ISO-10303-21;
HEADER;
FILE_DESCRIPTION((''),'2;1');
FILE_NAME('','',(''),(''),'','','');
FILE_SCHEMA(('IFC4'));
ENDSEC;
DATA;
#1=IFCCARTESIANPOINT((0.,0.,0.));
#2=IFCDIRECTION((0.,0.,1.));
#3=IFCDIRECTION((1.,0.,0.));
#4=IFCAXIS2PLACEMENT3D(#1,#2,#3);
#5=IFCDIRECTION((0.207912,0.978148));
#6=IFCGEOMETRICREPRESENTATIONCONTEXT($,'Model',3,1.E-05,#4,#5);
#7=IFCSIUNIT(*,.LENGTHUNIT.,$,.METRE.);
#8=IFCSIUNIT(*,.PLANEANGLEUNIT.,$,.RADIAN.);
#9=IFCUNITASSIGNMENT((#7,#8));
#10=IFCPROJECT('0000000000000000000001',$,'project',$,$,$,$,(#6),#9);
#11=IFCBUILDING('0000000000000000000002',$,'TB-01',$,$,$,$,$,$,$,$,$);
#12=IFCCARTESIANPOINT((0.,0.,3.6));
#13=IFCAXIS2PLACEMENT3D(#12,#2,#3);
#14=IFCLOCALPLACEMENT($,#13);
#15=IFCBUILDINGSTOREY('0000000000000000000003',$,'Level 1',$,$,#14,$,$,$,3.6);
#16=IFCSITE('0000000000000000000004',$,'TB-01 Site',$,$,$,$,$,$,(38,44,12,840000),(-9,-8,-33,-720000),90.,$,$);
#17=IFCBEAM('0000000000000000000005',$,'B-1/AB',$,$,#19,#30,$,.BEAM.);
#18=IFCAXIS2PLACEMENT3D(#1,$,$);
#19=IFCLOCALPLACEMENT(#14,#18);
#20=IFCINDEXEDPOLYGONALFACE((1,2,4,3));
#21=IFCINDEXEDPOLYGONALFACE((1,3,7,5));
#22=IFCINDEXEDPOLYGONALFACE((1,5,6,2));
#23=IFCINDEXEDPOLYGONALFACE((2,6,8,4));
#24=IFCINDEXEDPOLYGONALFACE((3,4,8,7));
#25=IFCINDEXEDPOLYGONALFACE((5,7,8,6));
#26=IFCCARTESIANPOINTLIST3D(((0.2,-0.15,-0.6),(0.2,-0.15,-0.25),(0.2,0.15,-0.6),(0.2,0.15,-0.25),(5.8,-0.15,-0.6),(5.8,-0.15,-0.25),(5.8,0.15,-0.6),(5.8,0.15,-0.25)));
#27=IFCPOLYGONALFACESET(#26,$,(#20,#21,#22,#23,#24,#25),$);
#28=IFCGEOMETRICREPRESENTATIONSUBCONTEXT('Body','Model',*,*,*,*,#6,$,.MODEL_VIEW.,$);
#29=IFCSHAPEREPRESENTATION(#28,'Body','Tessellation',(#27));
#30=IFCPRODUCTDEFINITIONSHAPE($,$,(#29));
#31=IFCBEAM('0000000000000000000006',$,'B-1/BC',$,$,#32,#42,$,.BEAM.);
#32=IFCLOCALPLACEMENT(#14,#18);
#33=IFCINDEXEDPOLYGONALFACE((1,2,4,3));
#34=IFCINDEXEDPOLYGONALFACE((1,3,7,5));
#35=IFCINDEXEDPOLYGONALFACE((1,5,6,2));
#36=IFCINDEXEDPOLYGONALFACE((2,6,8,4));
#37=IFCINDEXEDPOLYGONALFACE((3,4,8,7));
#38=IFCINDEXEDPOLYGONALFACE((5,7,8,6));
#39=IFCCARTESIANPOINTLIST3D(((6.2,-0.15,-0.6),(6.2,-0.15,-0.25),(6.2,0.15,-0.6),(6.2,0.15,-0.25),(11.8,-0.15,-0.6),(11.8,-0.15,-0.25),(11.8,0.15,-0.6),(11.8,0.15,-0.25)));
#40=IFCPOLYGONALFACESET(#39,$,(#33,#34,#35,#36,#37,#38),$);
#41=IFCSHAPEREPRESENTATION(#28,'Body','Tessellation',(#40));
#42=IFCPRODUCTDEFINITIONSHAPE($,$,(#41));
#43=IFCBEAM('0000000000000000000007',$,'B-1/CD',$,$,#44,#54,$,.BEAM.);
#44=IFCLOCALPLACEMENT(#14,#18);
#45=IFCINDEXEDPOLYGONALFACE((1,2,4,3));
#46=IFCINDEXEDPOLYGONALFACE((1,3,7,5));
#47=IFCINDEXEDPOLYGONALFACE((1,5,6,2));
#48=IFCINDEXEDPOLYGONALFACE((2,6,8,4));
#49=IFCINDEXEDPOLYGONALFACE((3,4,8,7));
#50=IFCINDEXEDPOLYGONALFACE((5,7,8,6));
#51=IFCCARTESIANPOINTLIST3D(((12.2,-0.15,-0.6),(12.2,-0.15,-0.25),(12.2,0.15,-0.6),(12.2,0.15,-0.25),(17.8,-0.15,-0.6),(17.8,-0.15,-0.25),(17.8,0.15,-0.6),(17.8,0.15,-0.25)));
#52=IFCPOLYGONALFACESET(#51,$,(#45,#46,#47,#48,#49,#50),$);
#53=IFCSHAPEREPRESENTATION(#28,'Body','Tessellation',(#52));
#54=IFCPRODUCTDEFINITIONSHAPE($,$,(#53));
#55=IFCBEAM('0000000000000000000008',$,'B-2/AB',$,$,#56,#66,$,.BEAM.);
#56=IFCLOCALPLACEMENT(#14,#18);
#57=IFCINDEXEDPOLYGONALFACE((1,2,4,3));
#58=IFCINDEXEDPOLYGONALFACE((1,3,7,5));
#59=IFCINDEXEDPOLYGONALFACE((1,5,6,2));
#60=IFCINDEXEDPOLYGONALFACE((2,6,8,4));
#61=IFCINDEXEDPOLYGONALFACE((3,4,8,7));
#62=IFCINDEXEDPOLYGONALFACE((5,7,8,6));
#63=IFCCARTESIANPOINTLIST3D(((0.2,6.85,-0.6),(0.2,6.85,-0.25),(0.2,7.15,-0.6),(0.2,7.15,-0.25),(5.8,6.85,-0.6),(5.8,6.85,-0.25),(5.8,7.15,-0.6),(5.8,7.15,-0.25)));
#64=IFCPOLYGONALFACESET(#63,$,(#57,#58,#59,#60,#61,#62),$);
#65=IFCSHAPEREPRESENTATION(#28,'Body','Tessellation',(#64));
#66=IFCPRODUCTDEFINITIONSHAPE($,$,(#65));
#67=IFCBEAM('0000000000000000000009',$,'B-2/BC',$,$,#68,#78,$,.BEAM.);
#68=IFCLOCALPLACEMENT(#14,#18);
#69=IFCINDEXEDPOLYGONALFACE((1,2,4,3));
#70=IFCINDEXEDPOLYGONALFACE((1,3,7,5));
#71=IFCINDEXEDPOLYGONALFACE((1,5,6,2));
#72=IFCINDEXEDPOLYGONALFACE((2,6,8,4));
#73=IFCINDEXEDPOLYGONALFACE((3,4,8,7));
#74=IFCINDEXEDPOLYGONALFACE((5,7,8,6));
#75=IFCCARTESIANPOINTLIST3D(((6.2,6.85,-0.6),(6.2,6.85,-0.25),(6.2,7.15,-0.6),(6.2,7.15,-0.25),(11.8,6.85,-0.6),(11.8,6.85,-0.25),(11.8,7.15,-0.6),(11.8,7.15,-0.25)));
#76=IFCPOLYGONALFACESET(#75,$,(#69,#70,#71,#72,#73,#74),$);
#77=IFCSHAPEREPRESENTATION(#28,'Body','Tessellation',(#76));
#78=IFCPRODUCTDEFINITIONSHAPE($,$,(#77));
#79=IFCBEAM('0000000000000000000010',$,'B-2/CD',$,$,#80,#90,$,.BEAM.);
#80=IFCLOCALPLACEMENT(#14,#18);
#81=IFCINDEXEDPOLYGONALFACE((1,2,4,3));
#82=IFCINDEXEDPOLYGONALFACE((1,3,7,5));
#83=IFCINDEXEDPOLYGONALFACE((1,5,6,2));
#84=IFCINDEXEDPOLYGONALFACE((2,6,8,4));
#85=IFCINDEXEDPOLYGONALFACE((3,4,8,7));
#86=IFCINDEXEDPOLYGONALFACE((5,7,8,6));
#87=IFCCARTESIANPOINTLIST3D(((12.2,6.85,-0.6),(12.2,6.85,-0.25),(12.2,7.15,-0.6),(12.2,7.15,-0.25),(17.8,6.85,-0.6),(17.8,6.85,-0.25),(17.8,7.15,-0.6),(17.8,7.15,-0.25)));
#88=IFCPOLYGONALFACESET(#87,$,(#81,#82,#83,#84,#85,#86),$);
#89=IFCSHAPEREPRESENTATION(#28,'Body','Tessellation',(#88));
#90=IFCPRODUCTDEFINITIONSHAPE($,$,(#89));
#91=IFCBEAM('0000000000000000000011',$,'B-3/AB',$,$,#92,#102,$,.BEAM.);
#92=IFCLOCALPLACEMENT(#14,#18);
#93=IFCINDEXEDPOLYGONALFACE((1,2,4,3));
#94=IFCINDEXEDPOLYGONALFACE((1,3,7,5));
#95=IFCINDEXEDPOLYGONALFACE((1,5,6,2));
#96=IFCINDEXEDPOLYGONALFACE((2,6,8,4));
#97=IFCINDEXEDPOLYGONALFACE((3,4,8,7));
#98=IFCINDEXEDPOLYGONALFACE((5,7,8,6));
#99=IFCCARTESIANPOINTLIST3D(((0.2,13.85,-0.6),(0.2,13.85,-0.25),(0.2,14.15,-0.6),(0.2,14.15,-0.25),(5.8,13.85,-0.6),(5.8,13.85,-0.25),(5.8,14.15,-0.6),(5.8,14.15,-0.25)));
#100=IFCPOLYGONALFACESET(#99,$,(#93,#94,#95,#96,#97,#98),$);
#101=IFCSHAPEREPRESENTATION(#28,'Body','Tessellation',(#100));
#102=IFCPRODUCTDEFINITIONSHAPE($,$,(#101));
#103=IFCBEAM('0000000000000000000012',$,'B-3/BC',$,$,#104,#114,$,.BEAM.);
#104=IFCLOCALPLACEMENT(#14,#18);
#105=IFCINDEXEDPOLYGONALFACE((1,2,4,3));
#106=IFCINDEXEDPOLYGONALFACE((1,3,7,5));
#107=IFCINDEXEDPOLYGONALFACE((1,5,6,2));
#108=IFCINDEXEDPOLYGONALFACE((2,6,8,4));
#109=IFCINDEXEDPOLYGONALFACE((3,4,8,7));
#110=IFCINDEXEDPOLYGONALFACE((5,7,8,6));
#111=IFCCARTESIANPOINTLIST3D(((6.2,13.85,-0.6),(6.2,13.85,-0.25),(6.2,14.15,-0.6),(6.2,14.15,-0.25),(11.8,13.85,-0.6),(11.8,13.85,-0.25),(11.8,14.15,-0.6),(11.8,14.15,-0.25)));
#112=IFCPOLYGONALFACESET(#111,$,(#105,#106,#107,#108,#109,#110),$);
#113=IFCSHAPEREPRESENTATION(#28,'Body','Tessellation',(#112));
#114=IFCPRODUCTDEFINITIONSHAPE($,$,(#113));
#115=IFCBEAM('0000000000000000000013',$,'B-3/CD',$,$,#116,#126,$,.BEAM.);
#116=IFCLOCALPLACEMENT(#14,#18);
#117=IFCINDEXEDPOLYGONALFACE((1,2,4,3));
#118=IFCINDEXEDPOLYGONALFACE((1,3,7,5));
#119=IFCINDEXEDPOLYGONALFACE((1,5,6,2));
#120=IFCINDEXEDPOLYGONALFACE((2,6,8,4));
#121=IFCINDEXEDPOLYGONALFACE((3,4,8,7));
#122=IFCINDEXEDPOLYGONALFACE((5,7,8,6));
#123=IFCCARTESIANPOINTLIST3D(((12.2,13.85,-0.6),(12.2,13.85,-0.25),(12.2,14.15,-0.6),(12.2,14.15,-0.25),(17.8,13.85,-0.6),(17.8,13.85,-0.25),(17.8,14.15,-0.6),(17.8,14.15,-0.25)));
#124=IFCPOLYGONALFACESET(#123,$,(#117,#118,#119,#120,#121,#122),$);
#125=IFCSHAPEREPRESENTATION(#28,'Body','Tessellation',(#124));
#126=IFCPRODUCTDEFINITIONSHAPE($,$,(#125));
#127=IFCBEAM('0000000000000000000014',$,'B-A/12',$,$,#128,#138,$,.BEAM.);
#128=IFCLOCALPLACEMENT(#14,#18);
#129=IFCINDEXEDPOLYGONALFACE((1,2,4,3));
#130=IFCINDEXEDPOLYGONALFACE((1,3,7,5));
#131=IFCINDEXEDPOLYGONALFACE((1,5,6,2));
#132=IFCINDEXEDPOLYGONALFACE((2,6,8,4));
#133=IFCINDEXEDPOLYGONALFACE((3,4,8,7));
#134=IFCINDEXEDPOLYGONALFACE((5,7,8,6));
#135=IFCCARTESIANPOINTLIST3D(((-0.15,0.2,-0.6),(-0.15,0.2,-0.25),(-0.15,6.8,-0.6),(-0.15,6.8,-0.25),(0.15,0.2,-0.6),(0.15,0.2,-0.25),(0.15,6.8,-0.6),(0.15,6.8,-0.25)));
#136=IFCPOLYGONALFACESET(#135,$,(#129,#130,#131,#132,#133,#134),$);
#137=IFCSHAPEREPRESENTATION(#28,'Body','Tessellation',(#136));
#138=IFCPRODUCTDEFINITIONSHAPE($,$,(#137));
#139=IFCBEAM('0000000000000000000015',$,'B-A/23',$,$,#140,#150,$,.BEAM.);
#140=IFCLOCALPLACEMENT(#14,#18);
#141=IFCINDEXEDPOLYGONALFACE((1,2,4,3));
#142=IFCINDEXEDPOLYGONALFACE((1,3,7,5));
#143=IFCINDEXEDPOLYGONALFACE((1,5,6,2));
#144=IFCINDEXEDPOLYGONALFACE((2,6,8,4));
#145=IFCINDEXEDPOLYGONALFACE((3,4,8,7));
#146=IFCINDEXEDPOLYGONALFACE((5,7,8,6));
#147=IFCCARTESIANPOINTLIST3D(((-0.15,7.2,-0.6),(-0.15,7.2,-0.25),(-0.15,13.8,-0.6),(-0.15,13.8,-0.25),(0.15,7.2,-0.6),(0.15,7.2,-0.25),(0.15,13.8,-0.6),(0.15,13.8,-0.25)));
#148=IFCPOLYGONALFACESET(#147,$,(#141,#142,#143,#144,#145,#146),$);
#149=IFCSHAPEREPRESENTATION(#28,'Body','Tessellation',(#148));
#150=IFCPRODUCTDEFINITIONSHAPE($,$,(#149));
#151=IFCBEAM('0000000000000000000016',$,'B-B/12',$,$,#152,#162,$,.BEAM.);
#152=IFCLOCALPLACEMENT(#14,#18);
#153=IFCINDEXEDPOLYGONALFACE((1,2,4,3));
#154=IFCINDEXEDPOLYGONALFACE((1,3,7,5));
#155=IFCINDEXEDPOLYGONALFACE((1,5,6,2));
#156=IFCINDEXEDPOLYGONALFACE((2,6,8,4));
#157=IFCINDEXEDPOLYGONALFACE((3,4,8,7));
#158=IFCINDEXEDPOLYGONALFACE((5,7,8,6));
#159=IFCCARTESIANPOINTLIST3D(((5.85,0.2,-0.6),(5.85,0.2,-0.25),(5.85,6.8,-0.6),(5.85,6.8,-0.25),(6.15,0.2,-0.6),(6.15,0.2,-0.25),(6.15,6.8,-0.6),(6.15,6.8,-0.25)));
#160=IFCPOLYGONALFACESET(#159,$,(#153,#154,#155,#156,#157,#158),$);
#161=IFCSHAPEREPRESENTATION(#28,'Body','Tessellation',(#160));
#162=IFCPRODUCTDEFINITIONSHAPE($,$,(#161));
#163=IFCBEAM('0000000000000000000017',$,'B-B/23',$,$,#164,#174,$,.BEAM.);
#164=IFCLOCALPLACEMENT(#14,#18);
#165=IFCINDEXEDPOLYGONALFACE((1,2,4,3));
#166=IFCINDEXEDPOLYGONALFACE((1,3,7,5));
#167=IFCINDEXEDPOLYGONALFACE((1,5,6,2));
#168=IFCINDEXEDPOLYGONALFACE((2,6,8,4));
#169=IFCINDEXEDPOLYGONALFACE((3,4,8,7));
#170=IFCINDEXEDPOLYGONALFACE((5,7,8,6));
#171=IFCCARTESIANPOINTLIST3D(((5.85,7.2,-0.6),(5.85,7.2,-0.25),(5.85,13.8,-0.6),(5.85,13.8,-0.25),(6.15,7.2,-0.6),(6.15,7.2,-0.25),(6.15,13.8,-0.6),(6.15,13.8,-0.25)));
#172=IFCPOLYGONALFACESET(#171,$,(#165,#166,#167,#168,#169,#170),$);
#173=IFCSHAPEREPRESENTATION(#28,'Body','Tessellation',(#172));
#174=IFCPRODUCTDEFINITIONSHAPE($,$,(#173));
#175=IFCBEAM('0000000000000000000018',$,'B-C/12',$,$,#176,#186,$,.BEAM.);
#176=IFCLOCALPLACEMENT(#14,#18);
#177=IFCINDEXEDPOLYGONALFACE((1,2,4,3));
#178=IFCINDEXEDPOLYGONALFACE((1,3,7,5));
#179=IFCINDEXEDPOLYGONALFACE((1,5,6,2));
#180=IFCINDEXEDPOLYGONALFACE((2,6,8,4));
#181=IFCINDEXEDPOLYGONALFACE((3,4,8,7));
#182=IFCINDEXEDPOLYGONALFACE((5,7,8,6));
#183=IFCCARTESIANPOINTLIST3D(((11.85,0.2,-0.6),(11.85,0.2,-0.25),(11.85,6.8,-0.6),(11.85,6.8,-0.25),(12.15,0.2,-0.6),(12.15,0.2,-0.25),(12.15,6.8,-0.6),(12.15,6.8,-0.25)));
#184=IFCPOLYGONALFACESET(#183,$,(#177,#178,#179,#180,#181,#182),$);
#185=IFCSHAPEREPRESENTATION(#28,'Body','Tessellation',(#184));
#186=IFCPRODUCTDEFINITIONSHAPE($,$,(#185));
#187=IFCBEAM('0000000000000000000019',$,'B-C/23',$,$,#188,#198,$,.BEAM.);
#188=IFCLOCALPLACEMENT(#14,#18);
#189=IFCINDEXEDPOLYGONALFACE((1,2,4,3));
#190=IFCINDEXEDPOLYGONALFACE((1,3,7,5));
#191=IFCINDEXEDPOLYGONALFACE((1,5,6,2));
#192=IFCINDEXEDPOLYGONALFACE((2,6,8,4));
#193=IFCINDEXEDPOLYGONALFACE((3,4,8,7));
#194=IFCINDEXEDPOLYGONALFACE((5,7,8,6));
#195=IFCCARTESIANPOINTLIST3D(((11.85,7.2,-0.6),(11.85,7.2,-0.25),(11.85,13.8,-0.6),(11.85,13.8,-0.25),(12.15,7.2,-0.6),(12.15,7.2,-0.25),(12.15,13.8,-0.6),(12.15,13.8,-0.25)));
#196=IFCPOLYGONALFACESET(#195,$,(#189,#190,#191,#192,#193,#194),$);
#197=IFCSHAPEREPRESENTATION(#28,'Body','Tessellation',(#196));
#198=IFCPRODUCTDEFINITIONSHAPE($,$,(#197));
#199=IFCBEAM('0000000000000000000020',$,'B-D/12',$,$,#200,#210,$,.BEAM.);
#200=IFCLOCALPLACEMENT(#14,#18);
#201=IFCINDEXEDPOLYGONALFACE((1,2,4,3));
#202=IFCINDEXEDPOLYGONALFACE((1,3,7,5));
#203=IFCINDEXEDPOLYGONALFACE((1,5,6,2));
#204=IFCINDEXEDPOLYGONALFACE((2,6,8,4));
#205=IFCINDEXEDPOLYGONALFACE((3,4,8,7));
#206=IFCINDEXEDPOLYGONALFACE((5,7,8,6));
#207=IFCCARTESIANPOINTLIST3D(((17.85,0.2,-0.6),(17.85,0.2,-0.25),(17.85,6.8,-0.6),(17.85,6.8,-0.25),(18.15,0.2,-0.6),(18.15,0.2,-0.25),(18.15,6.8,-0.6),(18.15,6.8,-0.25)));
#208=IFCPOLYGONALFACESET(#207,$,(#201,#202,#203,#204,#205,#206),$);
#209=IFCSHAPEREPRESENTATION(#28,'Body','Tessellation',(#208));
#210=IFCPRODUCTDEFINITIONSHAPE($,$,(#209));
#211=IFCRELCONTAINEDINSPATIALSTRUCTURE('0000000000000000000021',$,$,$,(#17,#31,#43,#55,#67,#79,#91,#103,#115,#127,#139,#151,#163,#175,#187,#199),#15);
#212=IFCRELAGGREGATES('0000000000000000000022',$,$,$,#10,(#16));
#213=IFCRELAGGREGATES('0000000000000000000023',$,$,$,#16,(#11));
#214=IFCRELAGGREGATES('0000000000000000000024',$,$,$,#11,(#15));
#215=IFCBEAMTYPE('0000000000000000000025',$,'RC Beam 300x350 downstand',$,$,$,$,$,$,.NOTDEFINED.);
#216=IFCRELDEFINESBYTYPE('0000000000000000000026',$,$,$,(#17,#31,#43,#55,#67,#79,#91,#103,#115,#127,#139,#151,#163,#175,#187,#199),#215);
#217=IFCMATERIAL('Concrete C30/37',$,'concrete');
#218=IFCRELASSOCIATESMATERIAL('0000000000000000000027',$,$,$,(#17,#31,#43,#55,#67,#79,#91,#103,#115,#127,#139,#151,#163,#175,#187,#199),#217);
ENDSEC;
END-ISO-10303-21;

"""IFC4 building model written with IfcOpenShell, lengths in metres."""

from ifc_helpers import new_model, si_unit, direction, frame, origin_with_axes, place, context, subcontext, project, spatial, rectangle, extrude, material, type_object, element, save


model = new_model("IFC4")

# Units and contexts
model_context = context("Model", 3, precision=1e-05, world=origin_with_axes(), true_north=direction((0.207912, 0.978148)))
body_context = subcontext(model_context, "Body", "Model", "MODEL_VIEW")
ifc_project = project(units=[si_unit("LENGTHUNIT", "METRE"), si_unit("PLANEANGLEUNIT", "RADIAN")], contexts=[model_context])

# Site, building, storey
site = spatial("IfcSite", under=ifc_project, Name="TB-01 Site", RefLatitude=(38, 44, 12, 840000), RefLongitude=(-9, -8, -33, -720000), RefElevation=90.0)
building = spatial("IfcBuilding", under=site, Name="TB-01")
storey_placement = place(None, frame((0.0, 0.0, 3.6), z_axis=(0.0, 0.0, 1.0), x_axis=(1.0, 0.0, 0.0)))
storey = spatial("IfcBuildingStorey", under=building, at=storey_placement, Name="Level 1", Elevation=3.6)

# Beams
ifc_material = material(Name="Concrete C30/37", Category="concrete")
beam_type = type_object("IfcBeamType", Name="RC Beam 300x350 downstand", PredefinedType="NOTDEFINED")
beam_1_placement = place(storey_placement, frame((0.2, 0.0, -0.425), z_axis=(1.0, 0.0, 0.0), x_axis=(0.0, 1.0, 0.0)))
element("IfcBeam", 1, at=beam_1_placement, inside=storey, type_object=beam_type, material=ifc_material, Name="B-1/AB", PredefinedType="BEAM", context=body_context, shape_type="SweptSolid", body=[
    extrude(rectangle(XDim=0.3, YDim=0.35), origin_with_axes(), (0.0, 0.0, 1.0), 5.6),
])
beam_2_placement = place(storey_placement, frame((6.2, 0.0, -0.425), z_axis=(1.0, 0.0, 0.0), x_axis=(0.0, 1.0, 0.0)))
element("IfcBeam", 2, at=beam_2_placement, inside=storey, type_object=beam_type, material=ifc_material, Name="B-1/BC", PredefinedType="BEAM", context=body_context, shape_type="SweptSolid", body=[
    extrude(rectangle(XDim=0.3, YDim=0.35), origin_with_axes(), (0.0, 0.0, 1.0), 5.6),
])
beam_3_placement = place(storey_placement, frame((12.2, 0.0, -0.425), z_axis=(1.0, 0.0, 0.0), x_axis=(0.0, 1.0, 0.0)))
element("IfcBeam", 3, at=beam_3_placement, inside=storey, type_object=beam_type, material=ifc_material, Name="B-1/CD", PredefinedType="BEAM", context=body_context, shape_type="SweptSolid", body=[
    extrude(rectangle(XDim=0.3, YDim=0.35), origin_with_axes(), (0.0, 0.0, 1.0), 5.6),
])
beam_4_placement = place(storey_placement, frame((0.2, 7.0, -0.425), z_axis=(1.0, 0.0, 0.0), x_axis=(0.0, 1.0, 0.0)))
element("IfcBeam", 4, at=beam_4_placement, inside=storey, type_object=beam_type, material=ifc_material, Name="B-2/AB", PredefinedType="BEAM", context=body_context, shape_type="SweptSolid", body=[
    extrude(rectangle(XDim=0.3, YDim=0.35), origin_with_axes(), (0.0, 0.0, 1.0), 5.6),
])
beam_5_placement = place(storey_placement, frame((6.2, 7.0, -0.425), z_axis=(1.0, 0.0, 0.0), x_axis=(0.0, 1.0, 0.0)))
element("IfcBeam", 5, at=beam_5_placement, inside=storey, type_object=beam_type, material=ifc_material, Name="B-2/BC", PredefinedType="BEAM", context=body_context, shape_type="SweptSolid", body=[
    extrude(rectangle(XDim=0.3, YDim=0.35), origin_with_axes(), (0.0, 0.0, 1.0), 5.6),
])
beam_6_placement = place(storey_placement, frame((12.2, 7.0, -0.425), z_axis=(1.0, 0.0, 0.0), x_axis=(0.0, 1.0, 0.0)))
element("IfcBeam", 6, at=beam_6_placement, inside=storey, type_object=beam_type, material=ifc_material, Name="B-2/CD", PredefinedType="BEAM", context=body_context, shape_type="SweptSolid", body=[
    extrude(rectangle(XDim=0.3, YDim=0.35), origin_with_axes(), (0.0, 0.0, 1.0), 5.6),
])
beam_7_placement = place(storey_placement, frame((0.2, 14.0, -0.425), z_axis=(1.0, 0.0, 0.0), x_axis=(0.0, 1.0, 0.0)))
element("IfcBeam", 7, at=beam_7_placement, inside=storey, type_object=beam_type, material=ifc_material, Name="B-3/AB", PredefinedType="BEAM", context=body_context, shape_type="SweptSolid", body=[
    extrude(rectangle(XDim=0.3, YDim=0.35), origin_with_axes(), (0.0, 0.0, 1.0), 5.6),
])
beam_8_placement = place(storey_placement, frame((6.2, 14.0, -0.425), z_axis=(1.0, 0.0, 0.0), x_axis=(0.0, 1.0, 0.0)))
element("IfcBeam", 8, at=beam_8_placement, inside=storey, type_object=beam_type, material=ifc_material, Name="B-3/BC", PredefinedType="BEAM", context=body_context, shape_type="SweptSolid", body=[
    extrude(rectangle(XDim=0.3, YDim=0.35), origin_with_axes(), (0.0, 0.0, 1.0), 5.6),
])
beam_9_placement = place(storey_placement, frame((12.2, 14.0, -0.425), z_axis=(1.0, 0.0, 0.0), x_axis=(0.0, 1.0, 0.0)))
element("IfcBeam", 9, at=beam_9_placement, inside=storey, type_object=beam_type, material=ifc_material, Name="B-3/CD", PredefinedType="BEAM", context=body_context, shape_type="SweptSolid", body=[
    extrude(rectangle(XDim=0.3, YDim=0.35), origin_with_axes(), (0.0, 0.0, 1.0), 5.6),
])
beam_10_placement = place(storey_placement, frame((0.0, 0.2, -0.425), z_axis=(0.0, 1.0, 0.0), x_axis=(-1.0, 0.0, 0.0)))
element("IfcBeam", 10, at=beam_10_placement, inside=storey, type_object=beam_type, material=ifc_material, Name="B-A/12", PredefinedType="BEAM", context=body_context, shape_type="SweptSolid", body=[
    extrude(rectangle(XDim=0.3, YDim=0.35), origin_with_axes(), (0.0, 0.0, 1.0), 6.6),
])
beam_11_placement = place(storey_placement, frame((0.0, 7.2, -0.425), z_axis=(0.0, 1.0, 0.0), x_axis=(-1.0, 0.0, 0.0)))
element("IfcBeam", 11, at=beam_11_placement, inside=storey, type_object=beam_type, material=ifc_material, Name="B-A/23", PredefinedType="BEAM", context=body_context, shape_type="SweptSolid", body=[
    extrude(rectangle(XDim=0.3, YDim=0.35), origin_with_axes(), (0.0, 0.0, 1.0), 6.6),
])
beam_12_placement = place(storey_placement, frame((6.0, 0.2, -0.425), z_axis=(0.0, 1.0, 0.0), x_axis=(-1.0, 0.0, 0.0)))
element("IfcBeam", 12, at=beam_12_placement, inside=storey, type_object=beam_type, material=ifc_material, Name="B-B/12", PredefinedType="BEAM", context=body_context, shape_type="SweptSolid", body=[
    extrude(rectangle(XDim=0.3, YDim=0.35), origin_with_axes(), (0.0, 0.0, 1.0), 6.6),
])
beam_13_placement = place(storey_placement, frame((6.0, 7.2, -0.425), z_axis=(0.0, 1.0, 0.0), x_axis=(-1.0, 0.0, 0.0)))
element("IfcBeam", 13, at=beam_13_placement, inside=storey, type_object=beam_type, material=ifc_material, Name="B-B/23", PredefinedType="BEAM", context=body_context, shape_type="SweptSolid", body=[
    extrude(rectangle(XDim=0.3, YDim=0.35), origin_with_axes(), (0.0, 0.0, 1.0), 6.6),
])
beam_14_placement = place(storey_placement, frame((12.0, 0.2, -0.425), z_axis=(0.0, 1.0, 0.0), x_axis=(-1.0, 0.0, 0.0)))
element("IfcBeam", 14, at=beam_14_placement, inside=storey, type_object=beam_type, material=ifc_material, Name="B-C/12", PredefinedType="BEAM", context=body_context, shape_type="SweptSolid", body=[
    extrude(rectangle(XDim=0.3, YDim=0.35), origin_with_axes(), (0.0, 0.0, 1.0), 6.6),
])
beam_15_placement = place(storey_placement, frame((12.0, 7.2, -0.425), z_axis=(0.0, 1.0, 0.0), x_axis=(-1.0, 0.0, 0.0)))
element("IfcBeam", 15, at=beam_15_placement, inside=storey, type_object=beam_type, material=ifc_material, Name="B-C/23", PredefinedType="BEAM", context=body_context, shape_type="SweptSolid", body=[
    extrude(rectangle(XDim=0.3, YDim=0.35), origin_with_axes(), (0.0, 0.0, 1.0), 6.6),
])
beam_16_placement = place(storey_placement, frame((18.0, 0.2, -0.425), z_axis=(0.0, 1.0, 0.0), x_axis=(-1.0, 0.0, 0.0)))
element("IfcBeam", 16, at=beam_16_placement, inside=storey, type_object=beam_type, material=ifc_material, Name="B-D/12", PredefinedType="BEAM", context=body_context, shape_type="SweptSolid", body=[
    extrude(rectangle(XDim=0.3, YDim=0.35), origin_with_axes(), (0.0, 0.0, 1.0), 6.6),
])

save(model, "model.ifc")
